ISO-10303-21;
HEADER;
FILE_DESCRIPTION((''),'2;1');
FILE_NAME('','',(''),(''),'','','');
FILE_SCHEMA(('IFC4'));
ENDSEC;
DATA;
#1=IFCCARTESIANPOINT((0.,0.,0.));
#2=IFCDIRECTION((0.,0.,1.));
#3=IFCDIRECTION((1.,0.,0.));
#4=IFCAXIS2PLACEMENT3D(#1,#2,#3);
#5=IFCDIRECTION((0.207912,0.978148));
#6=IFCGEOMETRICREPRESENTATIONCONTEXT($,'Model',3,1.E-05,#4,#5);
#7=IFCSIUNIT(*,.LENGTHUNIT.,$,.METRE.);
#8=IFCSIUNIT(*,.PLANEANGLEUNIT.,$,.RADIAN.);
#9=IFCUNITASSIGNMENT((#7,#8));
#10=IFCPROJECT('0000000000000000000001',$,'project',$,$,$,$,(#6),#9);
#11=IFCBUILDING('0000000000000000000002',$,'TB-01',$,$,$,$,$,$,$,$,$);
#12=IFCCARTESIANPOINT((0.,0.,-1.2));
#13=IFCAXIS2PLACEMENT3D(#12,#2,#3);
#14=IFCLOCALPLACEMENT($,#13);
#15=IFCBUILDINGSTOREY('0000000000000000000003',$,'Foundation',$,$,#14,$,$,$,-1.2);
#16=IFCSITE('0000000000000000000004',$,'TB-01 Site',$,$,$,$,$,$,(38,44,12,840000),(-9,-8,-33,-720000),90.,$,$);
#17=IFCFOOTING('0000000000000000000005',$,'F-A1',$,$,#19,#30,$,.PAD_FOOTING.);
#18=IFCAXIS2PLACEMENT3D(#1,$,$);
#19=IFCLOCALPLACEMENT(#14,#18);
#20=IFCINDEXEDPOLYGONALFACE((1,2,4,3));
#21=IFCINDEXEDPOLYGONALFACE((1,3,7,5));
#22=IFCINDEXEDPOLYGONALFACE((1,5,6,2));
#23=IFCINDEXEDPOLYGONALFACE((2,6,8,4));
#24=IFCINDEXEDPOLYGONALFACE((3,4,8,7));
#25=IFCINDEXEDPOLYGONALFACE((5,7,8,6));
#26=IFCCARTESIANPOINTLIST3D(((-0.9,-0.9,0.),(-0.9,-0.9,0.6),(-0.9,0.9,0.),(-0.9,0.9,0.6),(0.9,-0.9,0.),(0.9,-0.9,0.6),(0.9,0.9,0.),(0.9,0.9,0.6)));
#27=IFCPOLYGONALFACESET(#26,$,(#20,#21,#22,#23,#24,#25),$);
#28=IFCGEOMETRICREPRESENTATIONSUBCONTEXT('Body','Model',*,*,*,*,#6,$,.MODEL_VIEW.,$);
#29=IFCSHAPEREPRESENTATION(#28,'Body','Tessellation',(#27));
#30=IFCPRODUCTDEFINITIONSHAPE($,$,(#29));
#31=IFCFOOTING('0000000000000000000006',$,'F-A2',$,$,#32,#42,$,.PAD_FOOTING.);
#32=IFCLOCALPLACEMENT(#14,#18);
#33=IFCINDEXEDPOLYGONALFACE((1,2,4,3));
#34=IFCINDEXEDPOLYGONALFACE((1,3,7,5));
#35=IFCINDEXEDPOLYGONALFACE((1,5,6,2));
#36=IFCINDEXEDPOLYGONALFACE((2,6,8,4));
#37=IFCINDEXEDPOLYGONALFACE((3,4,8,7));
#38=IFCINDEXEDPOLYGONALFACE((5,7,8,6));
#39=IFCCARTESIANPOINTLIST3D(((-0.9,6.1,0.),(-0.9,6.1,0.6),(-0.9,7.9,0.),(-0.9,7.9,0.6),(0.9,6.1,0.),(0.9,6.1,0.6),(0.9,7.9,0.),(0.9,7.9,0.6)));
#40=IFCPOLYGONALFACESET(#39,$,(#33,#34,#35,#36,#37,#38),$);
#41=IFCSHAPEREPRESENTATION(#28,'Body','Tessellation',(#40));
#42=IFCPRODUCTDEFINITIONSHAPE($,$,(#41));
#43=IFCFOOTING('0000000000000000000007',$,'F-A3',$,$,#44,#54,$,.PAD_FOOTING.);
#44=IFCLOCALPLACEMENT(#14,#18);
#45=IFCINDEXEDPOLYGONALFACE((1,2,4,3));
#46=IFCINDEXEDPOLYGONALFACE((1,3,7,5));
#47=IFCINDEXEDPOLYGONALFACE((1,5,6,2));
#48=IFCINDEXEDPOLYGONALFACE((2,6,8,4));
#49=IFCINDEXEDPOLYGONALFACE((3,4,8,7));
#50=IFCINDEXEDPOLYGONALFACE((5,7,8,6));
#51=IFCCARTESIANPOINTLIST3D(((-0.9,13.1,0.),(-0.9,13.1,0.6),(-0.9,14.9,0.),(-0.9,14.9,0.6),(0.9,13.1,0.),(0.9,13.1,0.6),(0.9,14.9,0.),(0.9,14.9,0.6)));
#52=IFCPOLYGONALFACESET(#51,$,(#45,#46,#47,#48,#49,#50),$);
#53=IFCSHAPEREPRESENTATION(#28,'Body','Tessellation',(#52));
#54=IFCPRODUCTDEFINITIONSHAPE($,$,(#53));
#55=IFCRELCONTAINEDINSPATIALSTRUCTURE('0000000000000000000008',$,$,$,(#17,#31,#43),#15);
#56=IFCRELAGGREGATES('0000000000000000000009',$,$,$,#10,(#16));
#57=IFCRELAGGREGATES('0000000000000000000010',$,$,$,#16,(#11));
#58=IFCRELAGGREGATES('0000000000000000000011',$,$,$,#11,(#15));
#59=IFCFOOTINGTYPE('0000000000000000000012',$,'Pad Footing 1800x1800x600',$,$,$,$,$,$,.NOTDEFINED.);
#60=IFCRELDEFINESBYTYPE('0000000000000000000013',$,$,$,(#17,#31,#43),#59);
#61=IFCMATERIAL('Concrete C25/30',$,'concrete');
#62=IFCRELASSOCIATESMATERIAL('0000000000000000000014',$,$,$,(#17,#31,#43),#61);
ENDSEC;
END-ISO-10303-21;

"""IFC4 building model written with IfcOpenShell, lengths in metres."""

from ifc_helpers import new_model, si_unit, direction, frame, origin_with_axes, place, context, subcontext, project, spatial, rectangle, extrude, material, type_object, element, save


model = new_model("IFC4")

# Units and contexts
model_context = context("Model", 3, precision=1e-05, world=origin_with_axes(), true_north=direction((0.207912, 0.978148)))
body_context = subcontext(model_context, "Body", "Model", "MODEL_VIEW")
ifc_project = project(units=[si_unit("LENGTHUNIT", "METRE"), si_unit("PLANEANGLEUNIT", "RADIAN")], contexts=[model_context])

# Site, building, storey
site = spatial("IfcSite", under=ifc_project, Name="TB-01 Site", RefLatitude=(38, 44, 12, 840000), RefLongitude=(-9, -8, -33, -720000), RefElevation=90.0)
building = spatial("IfcBuilding", under=site, Name="TB-01")
storey_placement = place(None, frame((0.0, 0.0, -1.2), z_axis=(0.0, 0.0, 1.0), x_axis=(1.0, 0.0, 0.0)))
storey = spatial("IfcBuildingStorey", under=building, at=storey_placement, Name="Foundation", Elevation=-1.2)

# Footings
ifc_material_1 = material(Name="Concrete C25/30", Category="concrete")
footing_type = type_object("IfcFootingType", Name="Pad Footing 1800x1800x600", PredefinedType="NOTDEFINED")
footing_placement = place(storey_placement, origin_with_axes())
element("IfcFooting", 1, at=footing_placement, inside=storey, type_object=footing_type, material=ifc_material_1, Name="F-A1", PredefinedType="PAD_FOOTING", context=body_context, shape_type="SweptSolid", body=[
    extrude(rectangle(XDim=1.8, YDim=1.8), origin_with_axes(), (0.0, 0.0, 1.0), 0.6),
])
for number, where, z_axis, x_axis, name in (
    (2, (0.0, 7.0, 0.0), (0.0, 0.0, 1.0), (1.0, 0.0, 0.0), "F-A2"),
    (3, (0.0, 14.0, 0.0), (0.0, 0.0, 1.0), (1.0, 0.0, 0.0), "F-A3"),
):
    element("IfcFooting", number, at=place(storey_placement, frame(where, z_axis=z_axis, x_axis=x_axis)), inside=storey, type_object=footing_type, material=ifc_material_1, Name=name, PredefinedType="PAD_FOOTING", context=body_context, shape_type="SweptSolid", body=[
        extrude(rectangle(XDim=1.8, YDim=1.8), origin_with_axes(), (0.0, 0.0, 1.0), 0.6),
    ])

save(model, "model.ifc")
